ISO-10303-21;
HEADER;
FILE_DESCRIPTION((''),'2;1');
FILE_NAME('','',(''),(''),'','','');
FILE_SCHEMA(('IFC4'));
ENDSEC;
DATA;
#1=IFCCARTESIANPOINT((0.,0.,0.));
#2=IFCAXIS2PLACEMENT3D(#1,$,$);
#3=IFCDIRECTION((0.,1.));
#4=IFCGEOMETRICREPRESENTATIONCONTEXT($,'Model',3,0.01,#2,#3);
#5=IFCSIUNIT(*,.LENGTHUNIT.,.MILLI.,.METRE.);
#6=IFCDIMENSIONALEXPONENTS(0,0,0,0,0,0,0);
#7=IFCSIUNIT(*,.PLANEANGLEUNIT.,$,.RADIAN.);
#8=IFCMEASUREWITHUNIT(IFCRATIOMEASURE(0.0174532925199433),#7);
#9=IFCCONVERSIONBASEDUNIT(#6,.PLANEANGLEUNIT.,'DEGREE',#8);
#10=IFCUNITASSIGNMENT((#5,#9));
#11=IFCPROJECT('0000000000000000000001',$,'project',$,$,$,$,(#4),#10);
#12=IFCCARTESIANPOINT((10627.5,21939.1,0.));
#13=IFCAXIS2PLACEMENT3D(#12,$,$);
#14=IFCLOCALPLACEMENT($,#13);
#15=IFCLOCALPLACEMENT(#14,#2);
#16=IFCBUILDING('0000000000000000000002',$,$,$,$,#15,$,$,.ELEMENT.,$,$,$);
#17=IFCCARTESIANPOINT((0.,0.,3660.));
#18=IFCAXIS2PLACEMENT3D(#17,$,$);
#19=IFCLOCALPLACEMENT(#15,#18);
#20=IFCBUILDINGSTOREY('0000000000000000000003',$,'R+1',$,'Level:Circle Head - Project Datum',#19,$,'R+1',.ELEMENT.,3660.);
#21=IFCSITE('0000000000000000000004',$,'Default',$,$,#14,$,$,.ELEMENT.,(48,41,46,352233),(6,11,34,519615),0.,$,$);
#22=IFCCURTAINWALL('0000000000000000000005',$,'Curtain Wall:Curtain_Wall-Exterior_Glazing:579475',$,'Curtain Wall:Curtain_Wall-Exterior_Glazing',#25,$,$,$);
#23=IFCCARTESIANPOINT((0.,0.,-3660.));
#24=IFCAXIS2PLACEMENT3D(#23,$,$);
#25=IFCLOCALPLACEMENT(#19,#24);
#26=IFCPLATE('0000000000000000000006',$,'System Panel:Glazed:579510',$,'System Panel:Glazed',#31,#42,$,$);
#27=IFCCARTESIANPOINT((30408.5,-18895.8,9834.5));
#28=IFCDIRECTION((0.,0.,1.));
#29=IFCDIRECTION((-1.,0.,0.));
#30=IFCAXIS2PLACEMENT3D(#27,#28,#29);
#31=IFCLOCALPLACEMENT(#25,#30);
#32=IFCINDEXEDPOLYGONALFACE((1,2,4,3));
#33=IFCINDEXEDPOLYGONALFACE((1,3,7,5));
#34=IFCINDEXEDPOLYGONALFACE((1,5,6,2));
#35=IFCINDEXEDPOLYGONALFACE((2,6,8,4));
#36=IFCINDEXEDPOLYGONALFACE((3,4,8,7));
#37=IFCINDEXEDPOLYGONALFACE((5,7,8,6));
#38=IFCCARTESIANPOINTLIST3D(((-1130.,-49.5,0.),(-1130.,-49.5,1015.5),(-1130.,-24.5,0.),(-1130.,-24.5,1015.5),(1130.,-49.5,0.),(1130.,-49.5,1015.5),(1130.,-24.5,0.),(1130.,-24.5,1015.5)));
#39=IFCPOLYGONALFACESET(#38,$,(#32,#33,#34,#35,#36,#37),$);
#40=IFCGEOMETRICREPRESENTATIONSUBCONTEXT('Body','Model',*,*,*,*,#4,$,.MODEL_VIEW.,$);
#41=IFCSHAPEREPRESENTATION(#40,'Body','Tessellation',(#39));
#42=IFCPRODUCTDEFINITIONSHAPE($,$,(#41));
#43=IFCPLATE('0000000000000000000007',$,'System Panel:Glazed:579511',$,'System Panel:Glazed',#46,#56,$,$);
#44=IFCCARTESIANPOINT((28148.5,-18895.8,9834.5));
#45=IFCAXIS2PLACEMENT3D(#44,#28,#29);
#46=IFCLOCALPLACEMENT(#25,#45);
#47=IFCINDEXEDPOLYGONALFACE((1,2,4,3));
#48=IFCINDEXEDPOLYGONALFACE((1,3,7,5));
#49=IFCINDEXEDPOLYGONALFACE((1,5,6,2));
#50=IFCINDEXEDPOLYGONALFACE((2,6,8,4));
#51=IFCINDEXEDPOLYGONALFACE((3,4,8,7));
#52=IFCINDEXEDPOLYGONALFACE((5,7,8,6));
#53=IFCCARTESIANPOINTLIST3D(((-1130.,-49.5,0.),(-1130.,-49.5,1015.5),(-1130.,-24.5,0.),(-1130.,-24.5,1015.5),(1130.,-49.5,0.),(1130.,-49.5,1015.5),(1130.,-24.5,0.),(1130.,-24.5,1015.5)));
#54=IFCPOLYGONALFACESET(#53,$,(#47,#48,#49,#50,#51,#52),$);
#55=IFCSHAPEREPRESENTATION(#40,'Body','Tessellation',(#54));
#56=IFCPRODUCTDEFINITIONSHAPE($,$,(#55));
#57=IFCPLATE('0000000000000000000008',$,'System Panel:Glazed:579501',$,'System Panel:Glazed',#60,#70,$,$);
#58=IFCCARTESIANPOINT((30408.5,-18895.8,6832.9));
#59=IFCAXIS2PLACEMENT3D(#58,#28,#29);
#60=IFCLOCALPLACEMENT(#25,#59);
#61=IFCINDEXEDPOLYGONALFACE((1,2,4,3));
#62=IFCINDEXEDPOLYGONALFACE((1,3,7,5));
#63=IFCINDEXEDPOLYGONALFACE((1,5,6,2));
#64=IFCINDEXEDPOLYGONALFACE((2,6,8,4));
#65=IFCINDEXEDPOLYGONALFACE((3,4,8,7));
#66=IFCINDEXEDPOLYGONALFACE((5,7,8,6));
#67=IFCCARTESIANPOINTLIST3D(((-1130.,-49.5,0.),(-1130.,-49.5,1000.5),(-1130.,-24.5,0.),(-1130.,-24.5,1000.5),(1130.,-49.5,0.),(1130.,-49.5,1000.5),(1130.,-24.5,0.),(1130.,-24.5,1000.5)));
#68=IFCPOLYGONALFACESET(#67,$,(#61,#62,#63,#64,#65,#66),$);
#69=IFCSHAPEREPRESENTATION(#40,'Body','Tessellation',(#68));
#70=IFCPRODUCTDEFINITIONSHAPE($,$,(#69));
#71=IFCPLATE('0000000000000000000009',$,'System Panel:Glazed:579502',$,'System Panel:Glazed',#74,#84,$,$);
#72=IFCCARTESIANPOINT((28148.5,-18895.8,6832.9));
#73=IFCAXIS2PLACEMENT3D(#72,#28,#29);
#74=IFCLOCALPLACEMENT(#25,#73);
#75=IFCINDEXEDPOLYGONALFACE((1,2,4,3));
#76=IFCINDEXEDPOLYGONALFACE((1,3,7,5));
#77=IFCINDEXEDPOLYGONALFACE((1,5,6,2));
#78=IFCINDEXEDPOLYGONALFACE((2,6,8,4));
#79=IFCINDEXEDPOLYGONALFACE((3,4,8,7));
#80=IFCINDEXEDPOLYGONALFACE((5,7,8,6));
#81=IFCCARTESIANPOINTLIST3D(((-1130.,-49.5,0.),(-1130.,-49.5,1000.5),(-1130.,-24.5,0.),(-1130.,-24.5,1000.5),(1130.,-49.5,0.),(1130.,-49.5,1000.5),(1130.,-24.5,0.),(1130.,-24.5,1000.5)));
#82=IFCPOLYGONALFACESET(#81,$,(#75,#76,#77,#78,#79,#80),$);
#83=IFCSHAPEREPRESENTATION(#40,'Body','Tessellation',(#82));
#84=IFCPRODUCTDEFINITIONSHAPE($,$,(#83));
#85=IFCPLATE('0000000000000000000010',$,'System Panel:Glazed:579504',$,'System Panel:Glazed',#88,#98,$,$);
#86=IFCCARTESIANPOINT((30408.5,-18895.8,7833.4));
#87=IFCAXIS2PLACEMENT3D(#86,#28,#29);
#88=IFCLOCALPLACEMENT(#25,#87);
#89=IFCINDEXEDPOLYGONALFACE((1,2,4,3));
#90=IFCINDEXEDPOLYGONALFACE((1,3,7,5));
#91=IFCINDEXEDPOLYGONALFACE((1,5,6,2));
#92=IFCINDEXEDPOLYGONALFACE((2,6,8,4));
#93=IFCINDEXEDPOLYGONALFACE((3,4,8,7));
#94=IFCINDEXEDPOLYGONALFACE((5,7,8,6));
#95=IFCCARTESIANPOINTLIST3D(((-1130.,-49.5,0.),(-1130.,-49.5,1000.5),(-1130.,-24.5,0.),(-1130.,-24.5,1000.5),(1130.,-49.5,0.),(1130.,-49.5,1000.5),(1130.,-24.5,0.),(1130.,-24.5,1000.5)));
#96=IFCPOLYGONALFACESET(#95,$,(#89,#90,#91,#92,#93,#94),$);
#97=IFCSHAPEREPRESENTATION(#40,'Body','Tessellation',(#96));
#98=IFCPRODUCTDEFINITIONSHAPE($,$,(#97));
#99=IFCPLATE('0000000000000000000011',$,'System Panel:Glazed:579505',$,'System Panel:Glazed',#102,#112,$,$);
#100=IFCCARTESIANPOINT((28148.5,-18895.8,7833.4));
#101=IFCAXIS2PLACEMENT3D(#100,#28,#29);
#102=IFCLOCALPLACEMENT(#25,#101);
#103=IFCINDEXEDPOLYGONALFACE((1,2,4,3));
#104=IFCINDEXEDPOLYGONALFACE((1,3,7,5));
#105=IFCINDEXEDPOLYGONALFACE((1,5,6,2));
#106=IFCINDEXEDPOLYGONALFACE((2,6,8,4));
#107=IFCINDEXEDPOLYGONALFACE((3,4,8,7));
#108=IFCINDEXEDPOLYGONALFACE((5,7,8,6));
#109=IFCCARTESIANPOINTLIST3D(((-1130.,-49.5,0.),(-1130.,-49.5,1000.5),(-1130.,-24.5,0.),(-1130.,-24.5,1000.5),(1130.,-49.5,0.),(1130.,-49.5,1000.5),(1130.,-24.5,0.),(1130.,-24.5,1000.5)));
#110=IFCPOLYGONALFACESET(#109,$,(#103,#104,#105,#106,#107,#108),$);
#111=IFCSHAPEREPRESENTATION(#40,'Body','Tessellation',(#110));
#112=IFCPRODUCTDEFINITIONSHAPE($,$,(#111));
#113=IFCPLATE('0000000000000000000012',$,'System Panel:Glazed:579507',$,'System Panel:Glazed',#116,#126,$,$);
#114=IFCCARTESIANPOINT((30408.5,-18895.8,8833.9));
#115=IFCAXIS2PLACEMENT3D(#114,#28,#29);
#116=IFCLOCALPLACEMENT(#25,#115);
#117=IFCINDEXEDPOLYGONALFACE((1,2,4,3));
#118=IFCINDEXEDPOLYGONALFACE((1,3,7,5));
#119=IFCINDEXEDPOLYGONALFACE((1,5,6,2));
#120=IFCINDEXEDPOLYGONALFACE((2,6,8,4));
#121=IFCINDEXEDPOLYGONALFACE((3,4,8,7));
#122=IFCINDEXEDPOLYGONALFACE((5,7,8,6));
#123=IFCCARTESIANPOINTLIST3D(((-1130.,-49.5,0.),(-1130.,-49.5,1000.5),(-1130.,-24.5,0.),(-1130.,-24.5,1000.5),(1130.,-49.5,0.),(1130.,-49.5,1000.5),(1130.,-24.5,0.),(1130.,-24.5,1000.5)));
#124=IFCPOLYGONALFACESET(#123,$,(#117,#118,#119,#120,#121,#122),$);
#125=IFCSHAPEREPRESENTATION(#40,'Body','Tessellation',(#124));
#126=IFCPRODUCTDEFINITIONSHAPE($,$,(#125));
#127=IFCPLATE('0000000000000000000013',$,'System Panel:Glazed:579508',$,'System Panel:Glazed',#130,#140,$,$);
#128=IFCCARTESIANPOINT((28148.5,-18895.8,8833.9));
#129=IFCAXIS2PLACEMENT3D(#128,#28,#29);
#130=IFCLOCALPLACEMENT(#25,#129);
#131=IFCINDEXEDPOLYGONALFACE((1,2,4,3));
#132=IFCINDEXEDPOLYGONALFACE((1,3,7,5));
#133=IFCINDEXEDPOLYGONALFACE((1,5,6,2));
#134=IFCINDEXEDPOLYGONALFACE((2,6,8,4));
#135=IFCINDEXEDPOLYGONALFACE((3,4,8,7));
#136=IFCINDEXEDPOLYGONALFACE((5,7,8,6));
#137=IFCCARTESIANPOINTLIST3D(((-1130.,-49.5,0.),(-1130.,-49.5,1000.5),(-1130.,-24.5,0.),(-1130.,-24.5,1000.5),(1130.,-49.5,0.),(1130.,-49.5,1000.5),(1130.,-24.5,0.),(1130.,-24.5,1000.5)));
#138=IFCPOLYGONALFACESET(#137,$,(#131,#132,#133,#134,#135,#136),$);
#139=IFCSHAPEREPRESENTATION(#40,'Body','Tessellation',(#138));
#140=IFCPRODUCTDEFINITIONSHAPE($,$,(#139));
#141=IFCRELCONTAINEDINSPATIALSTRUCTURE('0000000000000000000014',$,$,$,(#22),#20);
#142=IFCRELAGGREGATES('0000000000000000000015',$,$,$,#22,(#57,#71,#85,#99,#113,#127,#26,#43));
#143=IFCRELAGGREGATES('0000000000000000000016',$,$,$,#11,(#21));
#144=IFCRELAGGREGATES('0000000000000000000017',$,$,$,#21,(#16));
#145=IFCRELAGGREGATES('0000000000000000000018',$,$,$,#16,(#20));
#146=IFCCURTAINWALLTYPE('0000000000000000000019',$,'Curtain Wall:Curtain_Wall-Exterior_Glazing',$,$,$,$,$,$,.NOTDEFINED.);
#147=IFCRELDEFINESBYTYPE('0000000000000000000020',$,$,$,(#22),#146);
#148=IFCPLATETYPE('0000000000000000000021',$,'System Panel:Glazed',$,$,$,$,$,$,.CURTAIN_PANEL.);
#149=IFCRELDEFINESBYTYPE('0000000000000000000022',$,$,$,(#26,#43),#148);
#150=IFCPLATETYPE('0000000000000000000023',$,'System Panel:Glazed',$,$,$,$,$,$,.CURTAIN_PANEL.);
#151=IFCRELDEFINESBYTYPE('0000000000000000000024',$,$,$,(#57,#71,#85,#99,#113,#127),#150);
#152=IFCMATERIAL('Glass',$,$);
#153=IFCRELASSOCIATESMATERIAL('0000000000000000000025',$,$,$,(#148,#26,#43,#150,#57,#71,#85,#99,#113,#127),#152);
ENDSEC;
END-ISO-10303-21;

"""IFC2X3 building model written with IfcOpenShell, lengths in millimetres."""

from ifc_helpers import new_model, entity, si_unit, converted_unit, direction, frame, frame_2d, origin, place, context, subcontext, project, spatial, rectangle, extrude, source, transform, mapped, material, type_object, type_shapes, element, aggregate, save


model = new_model("IFC2X3")

# Units and contexts
model_context = context("Model", 3, precision=0.01, world=origin(), true_north=direction((0.0, 1.0)))
body_context = subcontext(model_context, "Body", "Model", "MODEL_VIEW")
ifc_project = project(units=[si_unit("LENGTHUNIT", "METRE", prefix="MILLI"), converted_unit("PLANEANGLEUNIT", "DEGREE", entity("IfcRatioMeasure", 0.0174532925199433), si_unit("PLANEANGLEUNIT", "RADIAN"), dimensions=[0, 0, 0, 0, 0, 0, 0])], contexts=[model_context])

# Site, building, storey
site_placement = place(None, frame((10627.5, 21939.1, 0.0)))
site = spatial("IfcSite", under=ifc_project, at=site_placement, Name="Default", CompositionType="ELEMENT", RefLatitude=(48, 41, 46, 352233), RefLongitude=(6, 11, 34, 519615), RefElevation=0.0)
building_placement = place(site_placement, origin())
building = spatial("IfcBuilding", under=site, at=building_placement, CompositionType="ELEMENT")
storey_placement = place(building_placement, frame((0.0, 0.0, 3660.0)))
storey = spatial("IfcBuildingStorey", under=building, at=storey_placement, Name="R+1", ObjectType="Level:Circle Head - Project Datum", LongName="R+1", CompositionType="ELEMENT", Elevation=3660.0)

# Curtain wall, plates
curtain_wall_type = type_object("IfcCurtainWallType", Name="Curtain Wall:Curtain_Wall-Exterior_Glazing", PredefinedType="NOTDEFINED")
curtain_wall_placement = place(storey_placement, frame((0.0, 0.0, -3660.0)))
curtain_wall = element("IfcCurtainWall", 1, at=curtain_wall_placement, inside=storey, type_object=curtain_wall_type, Name="Curtain Wall:Curtain_Wall-Exterior_Glazing:579475", ObjectType="Curtain Wall:Curtain_Wall-Exterior_Glazing")
ifc_material_1 = material(Name="Glass")
plate_type_1 = type_object("IfcPlateType", Name="System Panel:Glazed", PredefinedType="CURTAIN_PANEL", material=ifc_material_1)
shared_shape_1 = source(origin(), body_context, "Body", "SweptSolid", [
    extrude(rectangle(XDim=25.0, YDim=2260.0, at=frame_2d((0.0, 0.0), x_axis=(1.0, 0.0))), frame((0.0, -37.0, 0.0), z_axis=(0.0, 0.0, 1.0), x_axis=(0.0, 1.0, 0.0)), (0.0, 0.0, 1.0), 1015.5),
])
type_shapes(plate_type_1, [shared_shape_1])
plate_1_placement = place(curtain_wall_placement, frame((30408.5, -18895.8, 9834.5), z_axis=(0.0, 0.0, 1.0), x_axis=(-1.0, 0.0, 0.0)))
plate_1 = element("IfcPlate", 2, at=plate_1_placement, type_object=plate_type_1, material=ifc_material_1, Name="System Panel:Glazed:579510", ObjectType="System Panel:Glazed", context=body_context, shape_type="MappedRepresentation", body=[
    mapped(shared_shape_1, transform((0.0, 0.0, 0.0), scale=1.0)),
])
plate_2_placement = place(curtain_wall_placement, frame((28148.5, -18895.8, 9834.5), z_axis=(0.0, 0.0, 1.0), x_axis=(-1.0, 0.0, 0.0)))
plate_2 = element("IfcPlate", 3, at=plate_2_placement, type_object=plate_type_1, material=ifc_material_1, Name="System Panel:Glazed:579511", ObjectType="System Panel:Glazed", context=body_context, shape_type="MappedRepresentation", body=[
    mapped(shared_shape_1, transform((0.0, 0.0, 0.0), scale=1.0)),
])
plate_type_2 = type_object("IfcPlateType", Name="System Panel:Glazed", PredefinedType="CURTAIN_PANEL", material=ifc_material_1)
shared_shape_2 = source(origin(), body_context, "Body", "SweptSolid", [
    extrude(rectangle(XDim=25.0, YDim=2260.0, at=frame_2d((0.0, 0.0), x_axis=(1.0, 0.0))), frame((0.0, -37.0, 0.0), z_axis=(0.0, 0.0, 1.0), x_axis=(0.0, 1.0, 0.0)), (0.0, 0.0, 1.0), 1000.5),
])
type_shapes(plate_type_2, [shared_shape_2])
plate_3_placement = place(curtain_wall_placement, frame((30408.5, -18895.8, 6832.9), z_axis=(0.0, 0.0, 1.0), x_axis=(-1.0, 0.0, 0.0)))
plate_3 = element("IfcPlate", 4, at=plate_3_placement, type_object=plate_type_2, material=ifc_material_1, Name="System Panel:Glazed:579501", ObjectType="System Panel:Glazed", context=body_context, shape_type="MappedRepresentation", body=[
    mapped(shared_shape_2, transform((0.0, 0.0, 0.0), scale=1.0)),
])
plate_4_placement = place(curtain_wall_placement, frame((28148.5, -18895.8, 6832.9), z_axis=(0.0, 0.0, 1.0), x_axis=(-1.0, 0.0, 0.0)))
plate_4 = element("IfcPlate", 5, at=plate_4_placement, type_object=plate_type_2, material=ifc_material_1, Name="System Panel:Glazed:579502", ObjectType="System Panel:Glazed", context=body_context, shape_type="MappedRepresentation", body=[
    mapped(shared_shape_2, transform((0.0, 0.0, 0.0), scale=1.0)),
])
plate_5_placement = place(curtain_wall_placement, frame((30408.5, -18895.8, 7833.4), z_axis=(0.0, 0.0, 1.0), x_axis=(-1.0, 0.0, 0.0)))
plate_5 = element("IfcPlate", 6, at=plate_5_placement, type_object=plate_type_2, material=ifc_material_1, Name="System Panel:Glazed:579504", ObjectType="System Panel:Glazed", context=body_context, shape_type="MappedRepresentation", body=[
    mapped(shared_shape_2, transform((0.0, 0.0, 0.0), scale=1.0)),
])
plate_6_placement = place(curtain_wall_placement, frame((28148.5, -18895.8, 7833.4), z_axis=(0.0, 0.0, 1.0), x_axis=(-1.0, 0.0, 0.0)))
plate_6 = element("IfcPlate", 7, at=plate_6_placement, type_object=plate_type_2, material=ifc_material_1, Name="System Panel:Glazed:579505", ObjectType="System Panel:Glazed", context=body_context, shape_type="MappedRepresentation", body=[
    mapped(shared_shape_2, transform((0.0, 0.0, 0.0), scale=1.0)),
])
plate_7_placement = place(curtain_wall_placement, frame((30408.5, -18895.8, 8833.9), z_axis=(0.0, 0.0, 1.0), x_axis=(-1.0, 0.0, 0.0)))
plate_7 = element("IfcPlate", 8, at=plate_7_placement, type_object=plate_type_2, material=ifc_material_1, Name="System Panel:Glazed:579507", ObjectType="System Panel:Glazed", context=body_context, shape_type="MappedRepresentation", body=[
    mapped(shared_shape_2, transform((0.0, 0.0, 0.0), scale=1.0)),
])
plate_8_placement = place(curtain_wall_placement, frame((28148.5, -18895.8, 8833.9), z_axis=(0.0, 0.0, 1.0), x_axis=(-1.0, 0.0, 0.0)))
plate_8 = element("IfcPlate", 9, at=plate_8_placement, type_object=plate_type_2, material=ifc_material_1, Name="System Panel:Glazed:579508", ObjectType="System Panel:Glazed", context=body_context, shape_type="MappedRepresentation", body=[
    mapped(shared_shape_2, transform((0.0, 0.0, 0.0), scale=1.0)),
])
aggregate(curtain_wall, [plate_3, plate_4, plate_5, plate_6, plate_7, plate_8, plate_1, plate_2])

save(model, "model.ifc")
